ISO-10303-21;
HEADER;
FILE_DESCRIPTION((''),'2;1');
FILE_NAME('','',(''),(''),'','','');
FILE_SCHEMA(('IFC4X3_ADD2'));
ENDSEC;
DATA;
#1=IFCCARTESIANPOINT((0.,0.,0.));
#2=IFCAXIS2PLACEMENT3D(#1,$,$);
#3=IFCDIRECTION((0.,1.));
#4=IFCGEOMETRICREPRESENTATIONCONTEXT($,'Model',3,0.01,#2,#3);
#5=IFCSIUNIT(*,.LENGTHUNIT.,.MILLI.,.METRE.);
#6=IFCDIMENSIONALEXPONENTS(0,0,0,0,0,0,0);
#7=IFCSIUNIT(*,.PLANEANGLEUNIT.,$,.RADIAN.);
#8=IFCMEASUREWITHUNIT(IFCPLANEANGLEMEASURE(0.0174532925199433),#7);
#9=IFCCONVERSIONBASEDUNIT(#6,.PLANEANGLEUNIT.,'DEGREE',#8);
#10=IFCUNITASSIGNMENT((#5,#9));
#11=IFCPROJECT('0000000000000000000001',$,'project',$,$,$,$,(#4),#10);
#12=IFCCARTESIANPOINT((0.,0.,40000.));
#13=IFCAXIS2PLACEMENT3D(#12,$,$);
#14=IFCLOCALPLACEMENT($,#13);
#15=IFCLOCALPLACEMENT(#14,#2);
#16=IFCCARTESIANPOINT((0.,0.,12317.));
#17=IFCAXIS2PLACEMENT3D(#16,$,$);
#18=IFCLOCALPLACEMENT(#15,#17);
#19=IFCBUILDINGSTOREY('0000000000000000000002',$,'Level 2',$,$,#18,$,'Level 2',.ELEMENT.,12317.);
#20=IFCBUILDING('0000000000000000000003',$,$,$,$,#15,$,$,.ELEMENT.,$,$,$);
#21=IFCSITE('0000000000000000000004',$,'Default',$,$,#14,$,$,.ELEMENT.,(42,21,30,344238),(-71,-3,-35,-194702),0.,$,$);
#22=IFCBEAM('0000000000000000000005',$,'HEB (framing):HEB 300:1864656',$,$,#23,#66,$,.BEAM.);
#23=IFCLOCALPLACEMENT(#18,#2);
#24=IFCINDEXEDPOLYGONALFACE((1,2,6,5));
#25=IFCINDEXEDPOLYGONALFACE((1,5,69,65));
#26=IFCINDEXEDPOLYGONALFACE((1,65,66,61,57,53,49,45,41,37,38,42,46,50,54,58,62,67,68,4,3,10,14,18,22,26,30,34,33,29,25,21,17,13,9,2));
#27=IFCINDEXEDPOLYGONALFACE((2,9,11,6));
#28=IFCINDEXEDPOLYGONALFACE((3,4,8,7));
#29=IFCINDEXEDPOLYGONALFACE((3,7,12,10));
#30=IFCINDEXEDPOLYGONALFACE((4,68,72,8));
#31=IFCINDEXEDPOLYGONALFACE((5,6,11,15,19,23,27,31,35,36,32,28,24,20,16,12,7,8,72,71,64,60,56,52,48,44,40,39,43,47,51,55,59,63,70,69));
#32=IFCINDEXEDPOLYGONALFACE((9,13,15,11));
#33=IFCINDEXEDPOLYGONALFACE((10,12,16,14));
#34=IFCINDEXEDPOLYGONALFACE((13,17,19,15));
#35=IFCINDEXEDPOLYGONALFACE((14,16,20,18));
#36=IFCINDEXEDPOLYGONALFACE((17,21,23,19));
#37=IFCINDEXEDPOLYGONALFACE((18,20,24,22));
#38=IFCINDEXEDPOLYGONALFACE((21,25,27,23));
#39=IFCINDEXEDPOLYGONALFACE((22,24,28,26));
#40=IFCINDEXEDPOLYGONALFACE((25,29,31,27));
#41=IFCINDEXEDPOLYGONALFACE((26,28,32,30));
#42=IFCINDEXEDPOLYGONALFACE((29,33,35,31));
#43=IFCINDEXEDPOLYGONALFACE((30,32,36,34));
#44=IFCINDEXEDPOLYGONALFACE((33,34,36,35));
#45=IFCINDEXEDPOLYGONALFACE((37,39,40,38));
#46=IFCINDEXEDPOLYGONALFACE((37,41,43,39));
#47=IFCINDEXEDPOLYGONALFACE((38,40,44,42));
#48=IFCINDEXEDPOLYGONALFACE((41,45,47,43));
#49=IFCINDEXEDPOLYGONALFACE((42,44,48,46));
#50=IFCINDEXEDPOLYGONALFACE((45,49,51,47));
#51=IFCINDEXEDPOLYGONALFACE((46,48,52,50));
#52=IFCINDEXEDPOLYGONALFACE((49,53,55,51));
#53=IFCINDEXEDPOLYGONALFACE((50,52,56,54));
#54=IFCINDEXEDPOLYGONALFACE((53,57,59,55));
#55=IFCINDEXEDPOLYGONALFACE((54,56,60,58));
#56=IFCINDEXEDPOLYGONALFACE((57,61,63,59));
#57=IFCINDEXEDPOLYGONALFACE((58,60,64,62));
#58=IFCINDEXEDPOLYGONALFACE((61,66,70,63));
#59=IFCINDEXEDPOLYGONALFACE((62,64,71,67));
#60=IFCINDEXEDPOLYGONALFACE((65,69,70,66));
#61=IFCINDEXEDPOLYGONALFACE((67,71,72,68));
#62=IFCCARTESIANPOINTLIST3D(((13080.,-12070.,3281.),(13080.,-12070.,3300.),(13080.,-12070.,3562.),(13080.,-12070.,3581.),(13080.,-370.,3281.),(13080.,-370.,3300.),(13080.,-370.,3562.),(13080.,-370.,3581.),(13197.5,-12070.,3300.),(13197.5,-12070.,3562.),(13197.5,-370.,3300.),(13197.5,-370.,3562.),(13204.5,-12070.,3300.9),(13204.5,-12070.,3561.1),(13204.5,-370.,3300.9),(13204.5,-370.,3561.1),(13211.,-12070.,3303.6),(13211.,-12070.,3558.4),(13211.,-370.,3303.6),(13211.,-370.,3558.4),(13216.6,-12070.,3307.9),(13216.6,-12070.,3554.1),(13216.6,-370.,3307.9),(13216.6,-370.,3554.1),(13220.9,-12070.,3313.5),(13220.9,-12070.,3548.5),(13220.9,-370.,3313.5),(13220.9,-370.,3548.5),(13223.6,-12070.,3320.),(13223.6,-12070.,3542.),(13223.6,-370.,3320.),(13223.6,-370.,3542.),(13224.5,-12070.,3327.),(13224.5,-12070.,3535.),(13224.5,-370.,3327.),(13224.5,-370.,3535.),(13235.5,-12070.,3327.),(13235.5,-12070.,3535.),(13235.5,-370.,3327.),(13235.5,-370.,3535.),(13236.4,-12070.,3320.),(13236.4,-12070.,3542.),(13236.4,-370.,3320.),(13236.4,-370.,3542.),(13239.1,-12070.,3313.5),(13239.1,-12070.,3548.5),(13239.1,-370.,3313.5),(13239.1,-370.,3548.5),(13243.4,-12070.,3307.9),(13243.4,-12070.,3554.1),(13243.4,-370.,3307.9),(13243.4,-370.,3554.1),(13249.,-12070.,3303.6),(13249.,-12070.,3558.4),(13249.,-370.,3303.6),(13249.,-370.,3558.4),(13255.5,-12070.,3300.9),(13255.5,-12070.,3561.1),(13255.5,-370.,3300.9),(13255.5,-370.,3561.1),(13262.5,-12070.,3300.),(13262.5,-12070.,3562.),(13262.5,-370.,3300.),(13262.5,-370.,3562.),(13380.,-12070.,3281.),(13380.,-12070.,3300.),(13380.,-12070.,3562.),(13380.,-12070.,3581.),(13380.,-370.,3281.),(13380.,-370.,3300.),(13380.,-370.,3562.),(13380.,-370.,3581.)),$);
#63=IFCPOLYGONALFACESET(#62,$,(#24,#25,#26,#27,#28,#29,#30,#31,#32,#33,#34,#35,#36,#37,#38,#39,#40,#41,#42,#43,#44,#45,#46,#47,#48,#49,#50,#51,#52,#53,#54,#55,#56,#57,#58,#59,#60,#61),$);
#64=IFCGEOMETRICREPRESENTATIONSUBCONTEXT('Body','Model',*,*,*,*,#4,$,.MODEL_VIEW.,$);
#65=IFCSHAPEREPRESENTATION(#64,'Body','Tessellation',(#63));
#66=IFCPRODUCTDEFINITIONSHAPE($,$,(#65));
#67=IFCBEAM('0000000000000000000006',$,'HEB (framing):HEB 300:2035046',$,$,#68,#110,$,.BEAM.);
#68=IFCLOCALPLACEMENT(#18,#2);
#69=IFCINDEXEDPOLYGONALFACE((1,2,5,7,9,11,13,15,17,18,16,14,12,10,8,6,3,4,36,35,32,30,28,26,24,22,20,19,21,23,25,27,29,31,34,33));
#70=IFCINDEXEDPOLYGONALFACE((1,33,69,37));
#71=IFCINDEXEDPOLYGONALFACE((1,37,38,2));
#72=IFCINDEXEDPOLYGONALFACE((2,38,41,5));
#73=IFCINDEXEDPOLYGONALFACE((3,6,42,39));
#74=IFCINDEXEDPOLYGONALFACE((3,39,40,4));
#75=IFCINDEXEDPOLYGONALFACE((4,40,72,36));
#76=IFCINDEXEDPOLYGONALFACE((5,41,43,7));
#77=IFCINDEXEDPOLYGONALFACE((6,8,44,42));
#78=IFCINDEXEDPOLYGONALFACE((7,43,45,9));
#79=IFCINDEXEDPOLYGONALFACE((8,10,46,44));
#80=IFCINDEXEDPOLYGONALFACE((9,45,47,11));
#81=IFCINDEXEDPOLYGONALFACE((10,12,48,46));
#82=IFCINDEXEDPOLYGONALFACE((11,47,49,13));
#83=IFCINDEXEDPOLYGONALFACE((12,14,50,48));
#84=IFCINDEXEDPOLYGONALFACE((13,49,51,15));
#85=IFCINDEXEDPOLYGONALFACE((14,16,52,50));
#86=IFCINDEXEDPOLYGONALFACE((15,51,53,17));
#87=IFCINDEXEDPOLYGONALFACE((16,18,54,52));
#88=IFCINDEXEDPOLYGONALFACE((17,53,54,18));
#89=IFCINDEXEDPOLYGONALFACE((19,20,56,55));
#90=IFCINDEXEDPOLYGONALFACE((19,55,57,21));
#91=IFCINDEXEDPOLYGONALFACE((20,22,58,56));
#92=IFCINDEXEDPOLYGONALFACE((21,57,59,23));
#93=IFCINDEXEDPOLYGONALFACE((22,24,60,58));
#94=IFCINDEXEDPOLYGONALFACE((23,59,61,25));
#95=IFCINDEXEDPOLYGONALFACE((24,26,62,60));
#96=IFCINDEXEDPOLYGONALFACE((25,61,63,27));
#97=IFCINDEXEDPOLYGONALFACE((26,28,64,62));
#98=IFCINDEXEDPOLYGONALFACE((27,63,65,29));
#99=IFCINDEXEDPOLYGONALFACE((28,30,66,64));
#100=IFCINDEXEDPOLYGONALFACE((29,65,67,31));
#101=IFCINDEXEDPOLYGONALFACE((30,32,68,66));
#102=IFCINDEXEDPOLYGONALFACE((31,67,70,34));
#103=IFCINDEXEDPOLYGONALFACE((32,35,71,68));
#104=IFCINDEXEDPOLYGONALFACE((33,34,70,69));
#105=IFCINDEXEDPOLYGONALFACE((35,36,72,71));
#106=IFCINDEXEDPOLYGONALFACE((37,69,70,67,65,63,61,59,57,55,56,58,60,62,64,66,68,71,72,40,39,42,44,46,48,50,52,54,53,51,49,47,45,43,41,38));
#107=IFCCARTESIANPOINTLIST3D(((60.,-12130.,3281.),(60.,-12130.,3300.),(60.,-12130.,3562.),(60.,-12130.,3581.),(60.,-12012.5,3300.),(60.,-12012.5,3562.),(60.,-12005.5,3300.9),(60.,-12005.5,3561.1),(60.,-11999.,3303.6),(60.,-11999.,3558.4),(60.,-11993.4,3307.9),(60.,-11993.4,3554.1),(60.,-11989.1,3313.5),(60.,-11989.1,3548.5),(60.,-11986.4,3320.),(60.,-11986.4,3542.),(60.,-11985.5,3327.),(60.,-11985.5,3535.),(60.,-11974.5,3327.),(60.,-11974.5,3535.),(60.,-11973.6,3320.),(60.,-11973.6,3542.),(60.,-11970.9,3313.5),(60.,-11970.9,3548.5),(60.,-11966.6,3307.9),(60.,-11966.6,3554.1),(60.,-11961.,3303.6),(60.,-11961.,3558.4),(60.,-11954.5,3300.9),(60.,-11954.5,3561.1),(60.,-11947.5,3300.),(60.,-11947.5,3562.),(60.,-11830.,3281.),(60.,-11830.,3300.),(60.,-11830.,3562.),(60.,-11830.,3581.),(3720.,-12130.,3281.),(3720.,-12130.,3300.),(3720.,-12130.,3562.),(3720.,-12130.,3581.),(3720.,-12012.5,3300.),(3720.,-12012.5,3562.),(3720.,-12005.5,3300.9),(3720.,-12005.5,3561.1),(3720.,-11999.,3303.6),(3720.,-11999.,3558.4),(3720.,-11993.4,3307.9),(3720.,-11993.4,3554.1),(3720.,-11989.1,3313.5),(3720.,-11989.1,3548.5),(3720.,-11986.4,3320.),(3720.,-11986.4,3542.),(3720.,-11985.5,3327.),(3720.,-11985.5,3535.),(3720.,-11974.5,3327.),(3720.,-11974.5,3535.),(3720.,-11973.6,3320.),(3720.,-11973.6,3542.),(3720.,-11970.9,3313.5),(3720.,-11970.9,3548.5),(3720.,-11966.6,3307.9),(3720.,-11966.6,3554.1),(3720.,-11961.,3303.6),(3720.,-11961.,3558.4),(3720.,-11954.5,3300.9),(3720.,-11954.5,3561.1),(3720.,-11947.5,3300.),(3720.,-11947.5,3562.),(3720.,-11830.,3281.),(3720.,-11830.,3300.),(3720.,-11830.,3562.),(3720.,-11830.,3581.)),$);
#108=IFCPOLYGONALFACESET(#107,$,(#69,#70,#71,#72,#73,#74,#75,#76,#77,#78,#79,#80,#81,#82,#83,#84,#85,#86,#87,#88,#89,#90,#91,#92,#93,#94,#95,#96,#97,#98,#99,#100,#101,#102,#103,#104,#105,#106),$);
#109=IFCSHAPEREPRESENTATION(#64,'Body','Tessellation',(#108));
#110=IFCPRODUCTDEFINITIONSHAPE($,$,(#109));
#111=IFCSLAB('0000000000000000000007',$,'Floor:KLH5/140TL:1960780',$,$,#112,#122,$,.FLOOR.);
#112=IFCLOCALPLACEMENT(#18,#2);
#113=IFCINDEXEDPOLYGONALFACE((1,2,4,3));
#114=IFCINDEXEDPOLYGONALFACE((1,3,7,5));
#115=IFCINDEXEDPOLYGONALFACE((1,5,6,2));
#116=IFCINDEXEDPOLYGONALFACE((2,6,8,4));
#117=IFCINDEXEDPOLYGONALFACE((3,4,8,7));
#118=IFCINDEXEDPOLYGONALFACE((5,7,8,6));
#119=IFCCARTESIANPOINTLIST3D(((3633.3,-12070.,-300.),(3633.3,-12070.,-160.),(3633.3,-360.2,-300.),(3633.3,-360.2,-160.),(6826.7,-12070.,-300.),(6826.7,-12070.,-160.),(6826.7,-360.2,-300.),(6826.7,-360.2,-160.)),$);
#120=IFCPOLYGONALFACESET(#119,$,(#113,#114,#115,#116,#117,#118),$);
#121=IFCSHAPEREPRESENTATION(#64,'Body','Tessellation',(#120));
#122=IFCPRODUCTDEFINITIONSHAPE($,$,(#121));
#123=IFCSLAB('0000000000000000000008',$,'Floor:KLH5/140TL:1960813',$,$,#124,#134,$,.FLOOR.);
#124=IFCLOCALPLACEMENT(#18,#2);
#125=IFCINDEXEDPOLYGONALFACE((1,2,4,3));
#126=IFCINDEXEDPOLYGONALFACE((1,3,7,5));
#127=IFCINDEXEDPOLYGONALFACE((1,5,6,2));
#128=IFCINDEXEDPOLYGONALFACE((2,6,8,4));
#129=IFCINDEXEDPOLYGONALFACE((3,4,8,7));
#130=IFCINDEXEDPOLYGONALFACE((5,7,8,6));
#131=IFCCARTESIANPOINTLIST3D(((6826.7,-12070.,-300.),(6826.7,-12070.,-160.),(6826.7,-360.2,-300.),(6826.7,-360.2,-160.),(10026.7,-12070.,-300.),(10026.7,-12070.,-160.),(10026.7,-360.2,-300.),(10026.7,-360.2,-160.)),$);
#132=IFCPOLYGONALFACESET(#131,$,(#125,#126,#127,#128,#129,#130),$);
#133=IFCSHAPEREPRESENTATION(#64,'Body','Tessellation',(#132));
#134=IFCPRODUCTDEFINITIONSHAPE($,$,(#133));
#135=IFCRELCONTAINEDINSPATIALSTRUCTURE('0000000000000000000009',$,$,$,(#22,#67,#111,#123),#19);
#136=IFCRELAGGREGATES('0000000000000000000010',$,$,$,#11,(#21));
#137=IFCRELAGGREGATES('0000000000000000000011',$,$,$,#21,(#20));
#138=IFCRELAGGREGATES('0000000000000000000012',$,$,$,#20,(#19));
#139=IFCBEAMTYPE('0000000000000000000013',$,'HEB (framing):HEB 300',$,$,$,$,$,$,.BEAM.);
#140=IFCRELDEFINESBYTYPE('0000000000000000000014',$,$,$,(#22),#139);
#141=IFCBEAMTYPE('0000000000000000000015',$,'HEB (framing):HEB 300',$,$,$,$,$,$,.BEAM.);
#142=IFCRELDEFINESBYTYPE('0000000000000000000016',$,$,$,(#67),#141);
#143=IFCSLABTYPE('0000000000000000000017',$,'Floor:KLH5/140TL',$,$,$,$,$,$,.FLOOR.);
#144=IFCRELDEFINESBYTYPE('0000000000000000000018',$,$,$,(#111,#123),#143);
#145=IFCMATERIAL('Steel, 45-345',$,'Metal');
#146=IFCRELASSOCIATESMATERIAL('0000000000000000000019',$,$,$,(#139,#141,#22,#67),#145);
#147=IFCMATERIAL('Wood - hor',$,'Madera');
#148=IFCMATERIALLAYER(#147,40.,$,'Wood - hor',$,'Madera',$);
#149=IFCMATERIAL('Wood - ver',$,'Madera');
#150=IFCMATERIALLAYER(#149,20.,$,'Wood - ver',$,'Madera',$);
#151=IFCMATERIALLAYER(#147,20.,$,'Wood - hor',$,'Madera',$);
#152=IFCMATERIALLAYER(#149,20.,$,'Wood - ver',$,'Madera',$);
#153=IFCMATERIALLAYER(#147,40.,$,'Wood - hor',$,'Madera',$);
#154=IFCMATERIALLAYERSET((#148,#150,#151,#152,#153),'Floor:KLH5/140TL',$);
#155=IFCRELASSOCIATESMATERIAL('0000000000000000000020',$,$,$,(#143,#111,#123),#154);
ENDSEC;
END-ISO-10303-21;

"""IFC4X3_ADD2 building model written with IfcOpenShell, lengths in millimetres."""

from ifc_helpers import new_model, entity, si_unit, converted_unit, direction, frame, frame_2d, origin, place, context, subcontext, project, spatial, polyline, circle_curve, parameter, trimmed, segment, composite_curve, rectangle, outline, extrude, source, transform, mapped, material, layer, layer_set, layer_usage, material_profile, profile_set, profile_usage, type_object, type_shapes, element, save


model = new_model("IFC4X3_ADD2")

# Units and contexts
model_context = context("Model", 3, precision=0.01, world=origin(), true_north=direction((0.0, 1.0)))
body_context = subcontext(model_context, "Body", "Model", "MODEL_VIEW")
ifc_project = project(units=[si_unit("LENGTHUNIT", "METRE", prefix="MILLI"), converted_unit("PLANEANGLEUNIT", "DEGREE", entity("IfcPlaneAngleMeasure", 0.0174532925199433), si_unit("PLANEANGLEUNIT", "RADIAN"), dimensions=[0, 0, 0, 0, 0, 0, 0])], contexts=[model_context])

# Site, building, storey
site_placement = place(None, frame((0.0, 0.0, 40000.0)))
site = spatial("IfcSite", under=ifc_project, at=site_placement, Name="Default", CompositionType="ELEMENT", RefLatitude=(42, 21, 30, 344238), RefLongitude=(-71, -3, -35, -194702), RefElevation=0.0)
building_placement = place(site_placement, origin())
building = spatial("IfcBuilding", under=site, at=building_placement, CompositionType="ELEMENT")
storey_placement = place(building_placement, frame((0.0, 0.0, 12317.0)))
storey = spatial("IfcBuildingStorey", under=building, at=storey_placement, Name="Level 2", LongName="Level 2", CompositionType="ELEMENT", Elevation=12317.0)

# Shared definitions
ifc_material_1 = material(Name="Steel, 45-345", Category="Metal")

# Beams
ifc_material_profile_1 = material_profile(ifc_material_1, outline(composite_curve([segment(polyline([(-150.0, -131.0), (-150.0, -150.0)]), True, "CONTINUOUS"), segment(polyline([(-150.0, -150.0), (150.0, -150.0)]), True, "CONTINUOUS"), segment(polyline([(150.0, -150.0), (150.0, -131.0)]), True, "CONTINUOUS"), segment(polyline([(150.0, -131.0), (32.5, -131.0)]), True, "CONTINUOUS"), segment(trimmed(circle_curve(frame_2d((32.5, -104.0), x_axis=(1.0, 0.0)), 27.0), [parameter(180.0)], [parameter(270.0)], True, "PARAMETER"), False, "CONTINUOUS"), segment(polyline([(5.5, -104.0), (5.5, 104.0)]), True, "CONTINUOUS"), segment(trimmed(circle_curve(frame_2d((32.5, 104.0), x_axis=(1.0, 0.0)), 27.0), [parameter(90.0)], [parameter(180.0)], True, "PARAMETER"), False, "CONTINUOUS"), segment(polyline([(32.5, 131.0), (150.0, 131.0)]), True, "CONTINUOUS"), segment(polyline([(150.0, 131.0), (150.0, 150.0)]), True, "CONTINUOUS"), segment(polyline([(150.0, 150.0), (-150.0, 150.0)]), True, "CONTINUOUS"), segment(polyline([(-150.0, 150.0), (-150.0, 131.0)]), True, "CONTINUOUS"), segment(polyline([(-150.0, 131.0), (-32.5, 131.0)]), True, "CONTINUOUS"), segment(trimmed(circle_curve(frame_2d((-32.5, 104.0), x_axis=(1.0, 0.0)), 27.0), [parameter(360.0)], [parameter(90.0)], True, "PARAMETER"), False, "CONTINUOUS"), segment(polyline([(-5.5, 104.0), (-5.5, -104.0)]), True, "CONTINUOUS"), segment(trimmed(circle_curve(frame_2d((-32.5, -104.0), x_axis=(1.0, 0.0)), 27.0), [parameter(270.0)], [parameter(0.0)], True, "PARAMETER"), False, "CONTINUOUS"), segment(polyline([(-32.5, -131.0), (-150.0, -131.0)]), True, "CONTINUOUS")], self_intersect=False)), Name="HEB 300")
ifc_profile_set_1 = profile_set([ifc_material_profile_1], Name="HEB 300")
ifc_profile_usage_1 = profile_usage(ifc_profile_set_1, cardinal=8)
beam_type_1 = type_object("IfcBeamType", Name="HEB (framing):HEB 300", PredefinedType="BEAM", material=ifc_profile_set_1)
shared_shape_1 = source(origin(), body_context, "Body", "SweptSolid", [
    extrude(outline(composite_curve([segment(polyline([(-150.0, -131.0), (-150.0, -150.0)]), True, "CONTINUOUS"), segment(polyline([(-150.0, -150.0), (150.0, -150.0)]), True, "CONTINUOUS"), segment(polyline([(150.0, -150.0), (150.0, -131.0)]), True, "CONTINUOUS"), segment(polyline([(150.0, -131.0), (32.5, -131.0)]), True, "CONTINUOUS"), segment(trimmed(circle_curve(frame_2d((32.5, -104.0), x_axis=(1.0, 0.0)), 27.0), [parameter(180.0)], [parameter(270.0)], True, "PARAMETER"), False, "CONTINUOUS"), segment(polyline([(5.5, -104.0), (5.5, 104.0)]), True, "CONTINUOUS"), segment(trimmed(circle_curve(frame_2d((32.5, 104.0), x_axis=(1.0, 0.0)), 27.0), [parameter(90.0)], [parameter(180.0)], True, "PARAMETER"), False, "CONTINUOUS"), segment(polyline([(32.5, 131.0), (150.0, 131.0)]), True, "CONTINUOUS"), segment(polyline([(150.0, 131.0), (150.0, 150.0)]), True, "CONTINUOUS"), segment(polyline([(150.0, 150.0), (-150.0, 150.0)]), True, "CONTINUOUS"), segment(polyline([(-150.0, 150.0), (-150.0, 131.0)]), True, "CONTINUOUS"), segment(polyline([(-150.0, 131.0), (-32.5, 131.0)]), True, "CONTINUOUS"), segment(trimmed(circle_curve(frame_2d((-32.5, 104.0), x_axis=(1.0, 0.0)), 27.0), [parameter(360.0)], [parameter(90.0)], True, "PARAMETER"), False, "CONTINUOUS"), segment(polyline([(-5.5, 104.0), (-5.5, -104.0)]), True, "CONTINUOUS"), segment(trimmed(circle_curve(frame_2d((-32.5, -104.0), x_axis=(1.0, 0.0)), 27.0), [parameter(270.0)], [parameter(0.0)], True, "PARAMETER"), False, "CONTINUOUS"), segment(polyline([(-32.5, -131.0), (-150.0, -131.0)]), True, "CONTINUOUS")], self_intersect=False)), frame((-5850.0, 0.0, 0.0), z_axis=(-1.0, 0.0, 0.0), x_axis=(0.0, -1.0, 0.0)), (0.0, 0.0, -1.0), 11700.0),
])
type_shapes(beam_type_1, [shared_shape_1])
for number, where, z_axis, x_axis, name in (
    (1, (13230.0, -6220.0, 3431.0), (0.0, 0.0, 1.0), (0.0, -1.0, 0.0), "HEB (framing):HEB 300:1864656"),
):
    element("IfcBeam", number, at=place(storey_placement, frame(where, z_axis=z_axis, x_axis=x_axis)), inside=storey, type_object=beam_type_1, material=ifc_profile_usage_1, Name=name, PredefinedType="BEAM", context=body_context, shape_type="MappedRepresentation", body=[
        mapped(shared_shape_1, transform((0.0, 0.0, 0.0), scale=1.0)),
    ])
beam_type_2 = type_object("IfcBeamType", Name="HEB (framing):HEB 300", PredefinedType="BEAM", material=ifc_profile_set_1)
shared_shape_2 = source(origin(), body_context, "Body", "SweptSolid", [
    extrude(outline(composite_curve([segment(polyline([(-150.0, -131.0), (-150.0, -150.0)]), True, "CONTINUOUS"), segment(polyline([(-150.0, -150.0), (150.0, -150.0)]), True, "CONTINUOUS"), segment(polyline([(150.0, -150.0), (150.0, -131.0)]), True, "CONTINUOUS"), segment(polyline([(150.0, -131.0), (32.5, -131.0)]), True, "CONTINUOUS"), segment(trimmed(circle_curve(frame_2d((32.5, -104.0), x_axis=(1.0, 0.0)), 27.0), [parameter(180.0)], [parameter(270.0)], True, "PARAMETER"), False, "CONTINUOUS"), segment(polyline([(5.5, -104.0), (5.5, 104.0)]), True, "CONTINUOUS"), segment(trimmed(circle_curve(frame_2d((32.5, 104.0), x_axis=(1.0, 0.0)), 27.0), [parameter(90.0)], [parameter(180.0)], True, "PARAMETER"), False, "CONTINUOUS"), segment(polyline([(32.5, 131.0), (150.0, 131.0)]), True, "CONTINUOUS"), segment(polyline([(150.0, 131.0), (150.0, 150.0)]), True, "CONTINUOUS"), segment(polyline([(150.0, 150.0), (-150.0, 150.0)]), True, "CONTINUOUS"), segment(polyline([(-150.0, 150.0), (-150.0, 131.0)]), True, "CONTINUOUS"), segment(polyline([(-150.0, 131.0), (-32.5, 131.0)]), True, "CONTINUOUS"), segment(trimmed(circle_curve(frame_2d((-32.5, 104.0), x_axis=(1.0, 0.0)), 27.0), [parameter(360.0)], [parameter(90.0)], True, "PARAMETER"), False, "CONTINUOUS"), segment(polyline([(-5.5, 104.0), (-5.5, -104.0)]), True, "CONTINUOUS"), segment(trimmed(circle_curve(frame_2d((-32.5, -104.0), x_axis=(1.0, 0.0)), 27.0), [parameter(270.0)], [parameter(0.0)], True, "PARAMETER"), False, "CONTINUOUS"), segment(polyline([(-32.5, -131.0), (-150.0, -131.0)]), True, "CONTINUOUS")], self_intersect=False)), frame((-1785.0, 0.0, 0.0), z_axis=(-1.0, 0.0, 0.0), x_axis=(0.0, -1.0, 0.0)), (0.0, 0.0, -1.0), 3660.0),
])
type_shapes(beam_type_2, [shared_shape_2])
beam_placement = place(storey_placement, frame((1935.0, -11980.0, 3431.0), z_axis=(0.0, 0.0, 1.0), x_axis=(-1.0, 0.0, 0.0)))
element("IfcBeam", 2, at=beam_placement, inside=storey, type_object=beam_type_2, material=ifc_profile_usage_1, Name="HEB (framing):HEB 300:2035046", PredefinedType="BEAM", context=body_context, shape_type="MappedRepresentation", body=[
    mapped(shared_shape_2, transform((0.0, 0.0, 0.0), scale=1.0)),
])

# Slabs
ifc_material_2 = material(Name="Wood - hor", Category="Madera")
ifc_layer_1 = layer(ifc_material_2, 40.0, Name="Wood - hor", Category="Madera")
ifc_material_3 = material(Name="Wood - ver", Category="Madera")
ifc_layer_2 = layer(ifc_material_3, 20.0, Name="Wood - ver", Category="Madera")
ifc_layer_3 = layer(ifc_material_2, 20.0, Name="Wood - hor", Category="Madera")
ifc_layer_4 = layer(ifc_material_3, 20.0, Name="Wood - ver", Category="Madera")
ifc_layer_5 = layer(ifc_material_2, 40.0, Name="Wood - hor", Category="Madera")
ifc_layer_set_1 = layer_set([ifc_layer_1, ifc_layer_2, ifc_layer_3, ifc_layer_4, ifc_layer_5], Name="Floor:KLH5/140TL")
ifc_layer_usage_1 = layer_usage(ifc_layer_set_1, "AXIS3", "POSITIVE", 0.0)
slab_type_1 = type_object("IfcSlabType", Name="Floor:KLH5/140TL", PredefinedType="FLOOR", material=ifc_layer_set_1)
slab_1_placement = place(storey_placement, origin())
element("IfcSlab", 3, at=slab_1_placement, inside=storey, type_object=slab_type_1, material=ifc_layer_usage_1, Name="Floor:KLH5/140TL:1960780", PredefinedType="FLOOR", context=body_context, shape_type="SweptSolid", body=[
    extrude(rectangle(XDim=11709.8, YDim=3193.4, at=frame_2d((0.0, 0.0), x_axis=(1.0, 0.0))), frame((5230.0, -6215.1, -160.0), z_axis=(0.0, 0.0, -1.0), x_axis=(0.0, 1.0, 0.0)), (0.0, 0.0, 1.0), 140.0),
])
ifc_layer_usage_2 = layer_usage(ifc_layer_set_1, "AXIS3", "POSITIVE", 0.0)
slab_2_placement = place(storey_placement, origin())
element("IfcSlab", 4, at=slab_2_placement, inside=storey, type_object=slab_type_1, material=ifc_layer_usage_2, Name="Floor:KLH5/140TL:1960813", PredefinedType="FLOOR", context=body_context, shape_type="SweptSolid", body=[
    extrude(rectangle(XDim=11709.8, YDim=3200.0, at=frame_2d((0.0, 0.0), x_axis=(1.0, 0.0))), frame((8426.7, -6215.1, -160.0), z_axis=(0.0, 0.0, -1.0), x_axis=(0.0, 1.0, 0.0)), (0.0, 0.0, 1.0), 140.0),
])

save(model, "model.ifc")
